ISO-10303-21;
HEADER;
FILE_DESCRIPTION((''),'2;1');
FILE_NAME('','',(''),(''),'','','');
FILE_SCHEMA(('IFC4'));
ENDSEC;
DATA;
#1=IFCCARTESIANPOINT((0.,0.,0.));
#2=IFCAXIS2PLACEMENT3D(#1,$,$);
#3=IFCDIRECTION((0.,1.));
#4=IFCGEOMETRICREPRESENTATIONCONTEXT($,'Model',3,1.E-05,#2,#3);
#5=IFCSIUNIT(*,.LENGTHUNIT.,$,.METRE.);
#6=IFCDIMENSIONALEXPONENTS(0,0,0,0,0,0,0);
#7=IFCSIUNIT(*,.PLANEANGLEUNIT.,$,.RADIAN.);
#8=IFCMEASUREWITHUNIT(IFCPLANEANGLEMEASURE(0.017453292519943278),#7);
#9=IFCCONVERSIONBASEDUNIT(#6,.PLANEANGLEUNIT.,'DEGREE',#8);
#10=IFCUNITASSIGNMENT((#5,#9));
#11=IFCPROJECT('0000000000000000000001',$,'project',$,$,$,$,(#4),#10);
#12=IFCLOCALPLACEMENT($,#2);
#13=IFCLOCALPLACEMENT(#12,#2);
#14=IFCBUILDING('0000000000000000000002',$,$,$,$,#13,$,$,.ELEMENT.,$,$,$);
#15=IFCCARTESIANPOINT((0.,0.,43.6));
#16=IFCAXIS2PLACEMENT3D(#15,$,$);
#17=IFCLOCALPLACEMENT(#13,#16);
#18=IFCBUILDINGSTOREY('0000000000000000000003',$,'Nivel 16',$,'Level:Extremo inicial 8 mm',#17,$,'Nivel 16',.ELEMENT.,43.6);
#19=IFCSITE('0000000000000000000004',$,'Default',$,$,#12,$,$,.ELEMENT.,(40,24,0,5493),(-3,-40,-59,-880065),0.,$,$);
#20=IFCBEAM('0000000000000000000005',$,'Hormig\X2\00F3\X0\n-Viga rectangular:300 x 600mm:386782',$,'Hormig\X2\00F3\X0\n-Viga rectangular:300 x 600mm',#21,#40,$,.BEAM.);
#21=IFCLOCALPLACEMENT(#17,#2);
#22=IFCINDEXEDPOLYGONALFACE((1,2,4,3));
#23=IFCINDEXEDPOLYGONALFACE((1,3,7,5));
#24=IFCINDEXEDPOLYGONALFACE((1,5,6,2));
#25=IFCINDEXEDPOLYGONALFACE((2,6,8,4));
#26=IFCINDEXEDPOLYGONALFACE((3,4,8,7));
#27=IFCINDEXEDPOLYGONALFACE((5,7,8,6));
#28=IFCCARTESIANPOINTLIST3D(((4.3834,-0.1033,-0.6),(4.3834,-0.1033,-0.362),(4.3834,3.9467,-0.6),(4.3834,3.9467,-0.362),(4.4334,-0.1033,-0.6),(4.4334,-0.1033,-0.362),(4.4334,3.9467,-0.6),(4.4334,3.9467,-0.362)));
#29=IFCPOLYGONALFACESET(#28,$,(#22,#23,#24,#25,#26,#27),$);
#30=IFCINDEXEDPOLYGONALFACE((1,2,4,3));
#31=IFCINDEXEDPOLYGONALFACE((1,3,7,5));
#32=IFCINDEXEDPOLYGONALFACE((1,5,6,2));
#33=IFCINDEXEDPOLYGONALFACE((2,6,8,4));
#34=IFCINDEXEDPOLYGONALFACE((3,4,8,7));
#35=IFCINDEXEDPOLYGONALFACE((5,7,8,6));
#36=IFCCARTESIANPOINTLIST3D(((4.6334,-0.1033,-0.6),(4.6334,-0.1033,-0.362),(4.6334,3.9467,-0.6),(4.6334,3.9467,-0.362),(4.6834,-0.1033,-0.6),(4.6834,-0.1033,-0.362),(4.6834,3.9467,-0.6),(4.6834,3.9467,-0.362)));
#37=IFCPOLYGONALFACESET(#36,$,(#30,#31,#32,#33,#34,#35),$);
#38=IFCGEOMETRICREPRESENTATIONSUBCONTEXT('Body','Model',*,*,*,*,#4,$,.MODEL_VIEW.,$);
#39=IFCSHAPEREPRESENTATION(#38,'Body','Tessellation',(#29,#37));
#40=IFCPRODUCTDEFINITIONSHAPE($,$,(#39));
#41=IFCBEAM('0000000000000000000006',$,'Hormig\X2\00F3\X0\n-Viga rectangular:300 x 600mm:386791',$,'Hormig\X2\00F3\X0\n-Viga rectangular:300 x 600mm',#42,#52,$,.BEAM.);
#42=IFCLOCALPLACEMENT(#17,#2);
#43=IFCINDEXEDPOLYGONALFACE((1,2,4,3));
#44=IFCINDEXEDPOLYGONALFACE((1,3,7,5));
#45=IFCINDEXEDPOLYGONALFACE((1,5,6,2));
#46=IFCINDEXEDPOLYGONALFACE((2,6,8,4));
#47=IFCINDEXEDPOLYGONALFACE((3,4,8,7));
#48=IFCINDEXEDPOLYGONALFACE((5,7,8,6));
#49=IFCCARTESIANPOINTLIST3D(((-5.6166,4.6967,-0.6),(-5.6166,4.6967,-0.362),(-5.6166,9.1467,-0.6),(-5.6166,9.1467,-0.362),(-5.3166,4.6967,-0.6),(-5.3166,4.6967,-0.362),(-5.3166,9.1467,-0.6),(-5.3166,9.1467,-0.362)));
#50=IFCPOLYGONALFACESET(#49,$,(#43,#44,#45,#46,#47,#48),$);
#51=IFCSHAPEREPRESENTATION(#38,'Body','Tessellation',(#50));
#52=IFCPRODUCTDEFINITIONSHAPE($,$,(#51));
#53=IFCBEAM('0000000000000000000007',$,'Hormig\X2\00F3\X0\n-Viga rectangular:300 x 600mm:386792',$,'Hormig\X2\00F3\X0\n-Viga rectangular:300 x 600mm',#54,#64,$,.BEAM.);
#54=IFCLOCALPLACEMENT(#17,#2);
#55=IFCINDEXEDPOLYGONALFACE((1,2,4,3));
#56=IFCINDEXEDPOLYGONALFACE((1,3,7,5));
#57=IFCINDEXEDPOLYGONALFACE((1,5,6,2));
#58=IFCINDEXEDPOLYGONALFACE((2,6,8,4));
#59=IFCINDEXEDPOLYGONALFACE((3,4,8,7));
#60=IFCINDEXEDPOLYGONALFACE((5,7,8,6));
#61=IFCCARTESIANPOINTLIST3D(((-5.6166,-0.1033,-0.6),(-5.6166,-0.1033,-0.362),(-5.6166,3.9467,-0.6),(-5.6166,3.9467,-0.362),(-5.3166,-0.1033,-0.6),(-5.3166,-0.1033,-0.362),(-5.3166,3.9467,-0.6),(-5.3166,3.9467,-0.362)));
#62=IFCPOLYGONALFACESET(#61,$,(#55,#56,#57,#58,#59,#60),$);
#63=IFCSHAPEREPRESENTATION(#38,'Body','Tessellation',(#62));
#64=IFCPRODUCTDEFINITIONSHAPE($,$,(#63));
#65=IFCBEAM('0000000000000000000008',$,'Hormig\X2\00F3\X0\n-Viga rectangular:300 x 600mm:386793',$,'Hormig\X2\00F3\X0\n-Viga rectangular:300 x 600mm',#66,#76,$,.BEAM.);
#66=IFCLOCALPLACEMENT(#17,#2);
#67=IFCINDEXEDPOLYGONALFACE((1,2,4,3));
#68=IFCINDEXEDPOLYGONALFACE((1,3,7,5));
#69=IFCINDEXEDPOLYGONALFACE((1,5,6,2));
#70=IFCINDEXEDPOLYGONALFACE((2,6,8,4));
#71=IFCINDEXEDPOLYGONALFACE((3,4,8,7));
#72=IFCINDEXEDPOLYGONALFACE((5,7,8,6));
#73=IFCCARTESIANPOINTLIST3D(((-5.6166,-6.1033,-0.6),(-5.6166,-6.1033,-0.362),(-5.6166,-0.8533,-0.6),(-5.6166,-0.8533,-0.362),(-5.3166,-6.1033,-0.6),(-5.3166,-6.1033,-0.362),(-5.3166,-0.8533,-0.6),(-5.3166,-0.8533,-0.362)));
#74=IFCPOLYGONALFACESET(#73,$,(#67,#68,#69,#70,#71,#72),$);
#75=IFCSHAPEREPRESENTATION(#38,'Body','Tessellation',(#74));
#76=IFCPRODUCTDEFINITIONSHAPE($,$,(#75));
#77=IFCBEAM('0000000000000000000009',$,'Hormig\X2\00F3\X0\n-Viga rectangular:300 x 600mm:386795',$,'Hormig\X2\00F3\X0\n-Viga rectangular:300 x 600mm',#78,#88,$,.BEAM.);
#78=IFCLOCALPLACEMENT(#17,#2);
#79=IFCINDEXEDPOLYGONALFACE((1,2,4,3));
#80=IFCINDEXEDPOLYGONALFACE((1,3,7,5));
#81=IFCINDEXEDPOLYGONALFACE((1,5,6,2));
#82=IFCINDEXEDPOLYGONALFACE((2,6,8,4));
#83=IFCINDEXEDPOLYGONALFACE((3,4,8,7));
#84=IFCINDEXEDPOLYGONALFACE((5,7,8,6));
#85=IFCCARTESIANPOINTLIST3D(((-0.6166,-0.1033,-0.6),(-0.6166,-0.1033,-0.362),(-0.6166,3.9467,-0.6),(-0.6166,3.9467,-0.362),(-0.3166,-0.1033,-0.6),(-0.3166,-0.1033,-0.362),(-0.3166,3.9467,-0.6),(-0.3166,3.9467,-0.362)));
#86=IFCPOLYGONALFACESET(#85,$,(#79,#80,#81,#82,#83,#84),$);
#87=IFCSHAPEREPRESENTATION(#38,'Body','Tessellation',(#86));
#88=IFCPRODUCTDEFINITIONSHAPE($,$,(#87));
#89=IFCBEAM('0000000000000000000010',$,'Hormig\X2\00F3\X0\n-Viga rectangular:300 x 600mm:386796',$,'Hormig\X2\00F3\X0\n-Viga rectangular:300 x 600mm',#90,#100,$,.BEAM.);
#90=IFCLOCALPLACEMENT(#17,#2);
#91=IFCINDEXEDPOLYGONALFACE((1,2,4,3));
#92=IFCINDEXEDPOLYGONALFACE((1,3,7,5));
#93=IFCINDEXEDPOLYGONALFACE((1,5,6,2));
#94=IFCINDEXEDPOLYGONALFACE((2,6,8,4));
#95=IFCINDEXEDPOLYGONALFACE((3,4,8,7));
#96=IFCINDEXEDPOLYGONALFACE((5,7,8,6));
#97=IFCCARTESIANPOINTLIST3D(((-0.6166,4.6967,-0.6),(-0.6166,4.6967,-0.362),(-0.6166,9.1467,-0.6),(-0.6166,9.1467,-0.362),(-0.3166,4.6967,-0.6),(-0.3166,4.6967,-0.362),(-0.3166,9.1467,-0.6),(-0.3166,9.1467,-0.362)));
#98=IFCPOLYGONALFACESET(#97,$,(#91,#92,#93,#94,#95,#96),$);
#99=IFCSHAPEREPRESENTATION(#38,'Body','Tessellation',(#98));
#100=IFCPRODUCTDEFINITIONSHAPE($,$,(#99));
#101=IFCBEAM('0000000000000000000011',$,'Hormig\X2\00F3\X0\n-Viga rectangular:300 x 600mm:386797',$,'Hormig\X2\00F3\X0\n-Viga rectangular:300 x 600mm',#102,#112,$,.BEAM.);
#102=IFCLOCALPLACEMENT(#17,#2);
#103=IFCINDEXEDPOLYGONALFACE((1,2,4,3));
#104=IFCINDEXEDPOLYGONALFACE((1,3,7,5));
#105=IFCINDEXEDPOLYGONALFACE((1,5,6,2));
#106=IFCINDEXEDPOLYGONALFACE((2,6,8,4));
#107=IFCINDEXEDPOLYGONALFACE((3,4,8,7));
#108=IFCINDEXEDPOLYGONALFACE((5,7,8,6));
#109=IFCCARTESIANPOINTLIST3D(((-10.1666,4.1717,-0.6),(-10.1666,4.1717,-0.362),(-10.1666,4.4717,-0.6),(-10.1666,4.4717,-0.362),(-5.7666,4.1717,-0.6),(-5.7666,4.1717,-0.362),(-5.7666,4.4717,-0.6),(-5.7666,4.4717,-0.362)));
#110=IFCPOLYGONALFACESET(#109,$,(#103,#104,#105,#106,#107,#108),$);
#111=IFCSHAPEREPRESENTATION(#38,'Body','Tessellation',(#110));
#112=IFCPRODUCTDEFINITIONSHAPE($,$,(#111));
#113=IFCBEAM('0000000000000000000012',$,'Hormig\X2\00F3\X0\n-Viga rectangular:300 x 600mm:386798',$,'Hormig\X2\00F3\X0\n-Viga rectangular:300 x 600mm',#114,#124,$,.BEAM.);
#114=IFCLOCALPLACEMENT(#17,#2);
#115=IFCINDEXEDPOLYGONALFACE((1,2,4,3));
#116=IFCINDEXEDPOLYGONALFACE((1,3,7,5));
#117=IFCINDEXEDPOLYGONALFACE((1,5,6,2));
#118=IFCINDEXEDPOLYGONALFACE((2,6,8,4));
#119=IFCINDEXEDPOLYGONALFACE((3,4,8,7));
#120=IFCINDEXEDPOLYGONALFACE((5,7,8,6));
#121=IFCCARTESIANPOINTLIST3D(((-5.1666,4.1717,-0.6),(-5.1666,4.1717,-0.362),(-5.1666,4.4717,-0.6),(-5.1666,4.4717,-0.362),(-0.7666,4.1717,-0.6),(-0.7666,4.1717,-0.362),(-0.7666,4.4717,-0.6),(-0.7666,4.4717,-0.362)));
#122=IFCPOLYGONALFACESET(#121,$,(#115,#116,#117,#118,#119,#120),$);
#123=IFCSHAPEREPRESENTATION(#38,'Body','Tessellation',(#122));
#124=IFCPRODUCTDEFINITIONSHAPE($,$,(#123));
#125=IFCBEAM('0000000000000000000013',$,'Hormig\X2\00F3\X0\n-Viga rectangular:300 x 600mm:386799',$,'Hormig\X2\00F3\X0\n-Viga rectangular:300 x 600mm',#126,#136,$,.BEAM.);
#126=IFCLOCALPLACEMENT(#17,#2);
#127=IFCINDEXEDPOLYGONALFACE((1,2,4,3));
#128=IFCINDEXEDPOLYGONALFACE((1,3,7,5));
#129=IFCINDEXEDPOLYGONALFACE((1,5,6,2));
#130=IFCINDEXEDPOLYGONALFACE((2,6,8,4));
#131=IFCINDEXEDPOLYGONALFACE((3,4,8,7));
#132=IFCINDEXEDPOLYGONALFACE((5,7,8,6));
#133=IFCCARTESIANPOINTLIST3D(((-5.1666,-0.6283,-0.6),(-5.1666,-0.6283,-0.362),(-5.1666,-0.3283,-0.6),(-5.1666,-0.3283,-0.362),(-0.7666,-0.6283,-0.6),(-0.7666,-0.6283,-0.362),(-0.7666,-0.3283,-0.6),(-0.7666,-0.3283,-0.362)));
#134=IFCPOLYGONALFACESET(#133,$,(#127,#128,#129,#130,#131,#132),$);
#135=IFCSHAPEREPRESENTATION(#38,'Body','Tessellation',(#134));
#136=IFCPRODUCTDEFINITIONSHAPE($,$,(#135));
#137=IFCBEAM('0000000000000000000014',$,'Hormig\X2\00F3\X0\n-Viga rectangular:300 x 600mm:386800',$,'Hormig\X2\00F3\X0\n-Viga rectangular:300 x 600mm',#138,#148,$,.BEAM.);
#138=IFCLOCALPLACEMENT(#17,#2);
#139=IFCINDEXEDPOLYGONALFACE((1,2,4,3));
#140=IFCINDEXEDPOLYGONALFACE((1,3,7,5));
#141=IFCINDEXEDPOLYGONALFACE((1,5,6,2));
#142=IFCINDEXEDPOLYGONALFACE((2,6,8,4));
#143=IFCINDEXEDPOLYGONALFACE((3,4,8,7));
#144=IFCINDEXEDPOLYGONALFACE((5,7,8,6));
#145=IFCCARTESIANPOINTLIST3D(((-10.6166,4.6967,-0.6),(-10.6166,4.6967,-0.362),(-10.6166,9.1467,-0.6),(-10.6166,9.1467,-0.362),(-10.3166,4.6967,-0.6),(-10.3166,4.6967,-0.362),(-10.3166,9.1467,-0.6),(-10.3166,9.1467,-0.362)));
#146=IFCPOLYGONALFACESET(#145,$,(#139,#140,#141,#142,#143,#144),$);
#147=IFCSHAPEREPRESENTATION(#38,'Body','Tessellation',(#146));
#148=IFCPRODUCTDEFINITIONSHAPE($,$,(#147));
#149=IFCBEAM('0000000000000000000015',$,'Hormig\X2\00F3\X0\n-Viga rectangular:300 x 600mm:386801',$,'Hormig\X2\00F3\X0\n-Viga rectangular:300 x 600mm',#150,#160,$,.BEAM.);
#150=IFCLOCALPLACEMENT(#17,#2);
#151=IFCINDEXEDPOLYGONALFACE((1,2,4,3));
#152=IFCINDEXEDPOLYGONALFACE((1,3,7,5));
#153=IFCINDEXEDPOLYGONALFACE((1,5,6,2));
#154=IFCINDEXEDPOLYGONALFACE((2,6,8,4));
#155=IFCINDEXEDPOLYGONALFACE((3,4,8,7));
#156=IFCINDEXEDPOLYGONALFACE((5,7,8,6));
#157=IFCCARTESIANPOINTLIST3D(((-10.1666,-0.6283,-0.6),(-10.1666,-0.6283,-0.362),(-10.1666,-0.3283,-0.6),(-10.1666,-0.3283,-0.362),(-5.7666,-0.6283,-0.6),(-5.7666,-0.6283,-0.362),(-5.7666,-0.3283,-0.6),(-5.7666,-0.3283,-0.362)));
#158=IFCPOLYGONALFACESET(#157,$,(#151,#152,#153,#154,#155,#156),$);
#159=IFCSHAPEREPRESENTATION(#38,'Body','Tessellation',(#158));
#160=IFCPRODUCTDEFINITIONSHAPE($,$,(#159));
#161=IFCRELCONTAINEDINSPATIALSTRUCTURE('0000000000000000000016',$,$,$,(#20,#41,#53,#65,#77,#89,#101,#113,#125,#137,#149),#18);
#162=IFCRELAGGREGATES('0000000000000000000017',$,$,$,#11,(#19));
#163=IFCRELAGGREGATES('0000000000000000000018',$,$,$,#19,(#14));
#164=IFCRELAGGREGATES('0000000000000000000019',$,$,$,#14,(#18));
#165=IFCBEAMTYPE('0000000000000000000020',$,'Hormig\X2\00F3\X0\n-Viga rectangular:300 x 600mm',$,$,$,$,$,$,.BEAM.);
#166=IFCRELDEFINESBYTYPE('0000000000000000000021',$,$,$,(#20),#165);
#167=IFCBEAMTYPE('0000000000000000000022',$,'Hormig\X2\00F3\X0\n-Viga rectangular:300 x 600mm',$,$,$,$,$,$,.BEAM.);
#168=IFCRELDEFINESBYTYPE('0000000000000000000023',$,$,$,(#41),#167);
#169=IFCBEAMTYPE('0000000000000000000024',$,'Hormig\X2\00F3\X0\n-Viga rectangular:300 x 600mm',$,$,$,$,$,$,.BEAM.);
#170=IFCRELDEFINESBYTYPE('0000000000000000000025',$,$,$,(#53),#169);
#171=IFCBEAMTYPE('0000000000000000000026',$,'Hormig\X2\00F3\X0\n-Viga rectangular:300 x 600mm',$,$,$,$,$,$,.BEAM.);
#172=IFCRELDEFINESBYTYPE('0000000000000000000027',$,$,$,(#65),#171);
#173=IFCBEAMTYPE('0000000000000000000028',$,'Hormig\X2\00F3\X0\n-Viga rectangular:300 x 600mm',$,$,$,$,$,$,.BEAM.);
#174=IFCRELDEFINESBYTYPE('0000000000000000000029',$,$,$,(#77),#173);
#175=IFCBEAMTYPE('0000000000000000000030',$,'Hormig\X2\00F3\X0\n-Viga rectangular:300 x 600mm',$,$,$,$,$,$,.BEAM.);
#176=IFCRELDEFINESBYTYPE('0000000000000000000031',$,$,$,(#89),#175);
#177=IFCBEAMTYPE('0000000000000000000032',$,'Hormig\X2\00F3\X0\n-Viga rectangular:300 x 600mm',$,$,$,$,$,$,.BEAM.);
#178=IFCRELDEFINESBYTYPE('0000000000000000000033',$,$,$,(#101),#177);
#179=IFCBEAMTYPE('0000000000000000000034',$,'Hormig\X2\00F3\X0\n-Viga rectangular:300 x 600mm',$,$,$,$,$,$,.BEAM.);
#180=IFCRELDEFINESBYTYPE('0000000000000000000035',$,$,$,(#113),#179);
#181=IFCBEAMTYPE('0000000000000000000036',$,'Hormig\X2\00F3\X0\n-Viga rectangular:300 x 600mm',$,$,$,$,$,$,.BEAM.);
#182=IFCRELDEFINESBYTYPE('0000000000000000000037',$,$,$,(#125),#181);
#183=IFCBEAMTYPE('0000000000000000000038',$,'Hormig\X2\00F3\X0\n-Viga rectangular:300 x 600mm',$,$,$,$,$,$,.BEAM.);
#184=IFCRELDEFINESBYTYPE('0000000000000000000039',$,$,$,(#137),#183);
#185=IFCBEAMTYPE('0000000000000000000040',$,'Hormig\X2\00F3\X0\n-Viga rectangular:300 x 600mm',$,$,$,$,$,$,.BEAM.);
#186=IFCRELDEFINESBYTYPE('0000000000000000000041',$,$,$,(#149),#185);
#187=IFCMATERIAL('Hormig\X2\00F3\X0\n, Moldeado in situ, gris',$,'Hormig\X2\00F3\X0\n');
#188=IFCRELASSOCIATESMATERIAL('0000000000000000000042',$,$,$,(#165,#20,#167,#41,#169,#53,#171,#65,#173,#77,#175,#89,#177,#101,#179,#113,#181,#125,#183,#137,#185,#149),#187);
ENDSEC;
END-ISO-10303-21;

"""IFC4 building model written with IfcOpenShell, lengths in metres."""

from ifc_helpers import new_model, entity, si_unit, converted_unit, direction, frame, origin, place, context, subcontext, project, spatial, indexed_curve, outline, extrude, source, transform, mapped, material, type_object, type_shapes, element, save


model = new_model("IFC4")

# Units and contexts
model_context = context("Model", 3, precision=1e-05, world=origin(), true_north=direction((0.0, 1.0)))
body_context = subcontext(model_context, "Body", "Model", "MODEL_VIEW")
ifc_project = project(units=[si_unit("LENGTHUNIT", "METRE"), converted_unit("PLANEANGLEUNIT", "DEGREE", entity("IfcPlaneAngleMeasure", 0.017453292519943278), si_unit("PLANEANGLEUNIT", "RADIAN"), dimensions=[0, 0, 0, 0, 0, 0, 0])], contexts=[model_context])

# Site, building, storey
site_placement = place(None, origin())
site = spatial("IfcSite", under=ifc_project, at=site_placement, Name="Default", CompositionType="ELEMENT", RefLatitude=(40, 24, 0, 5493), RefLongitude=(-3, -40, -59, -880065), RefElevation=0.0)
building_placement = place(site_placement, origin())
building = spatial("IfcBuilding", under=site, at=building_placement, CompositionType="ELEMENT")
storey_placement = place(building_placement, frame((0.0, 0.0, 43.6)))
storey = spatial("IfcBuildingStorey", under=building, at=storey_placement, Name="Nivel 16", ObjectType="Level:Extremo inicial 8 mm", LongName="Nivel 16", CompositionType="ELEMENT", Elevation=43.6)

# Shared definitions
ifc_material_1 = material(Name="Hormigón, Moldeado in situ, gris", Category="Hormigón")

# Beams
beam_type_1 = type_object("IfcBeamType", Name="Hormigón-Viga rectangular:300 x 600mm", PredefinedType="BEAM", material=ifc_material_1)
shared_shape_1 = source(origin(), body_context, "Body", "SweptSolid", [
    extrude(outline(indexed_curve([(-0.025, -0.119), (0.025, -0.119), (0.025, 0.119), (-0.025, 0.119), (-0.025, -0.119)], self_intersect=False)), frame((4.4084, 3.9467, 43.119), z_axis=(0.0, -1.0, 0.0), x_axis=(-1.0, 0.0, 0.0)), (0.0, 0.0, 1.0), 4.05),
    extrude(outline(indexed_curve([(-0.025, -0.119), (0.025, -0.119), (0.025, 0.119), (-0.025, 0.119), (-0.025, -0.119)], self_intersect=False)), frame((4.6584, 3.9467, 43.119), z_axis=(0.0, -1.0, 0.0), x_axis=(-1.0, 0.0, 0.0)), (0.0, 0.0, 1.0), 4.05),
])
type_shapes(beam_type_1, [shared_shape_1])
beam_1_placement = place(storey_placement, frame((0.0, 0.0, -43.6)))
element("IfcBeam", 1, at=beam_1_placement, inside=storey, type_object=beam_type_1, material=ifc_material_1, Name="Hormigón-Viga rectangular:300 x 600mm:386782", ObjectType="Hormigón-Viga rectangular:300 x 600mm", PredefinedType="BEAM", context=body_context, shape_type="MappedRepresentation", body=[
    mapped(shared_shape_1, transform((0.0, 0.0, 0.0), scale=1.0)),
])
beam_type_2 = type_object("IfcBeamType", Name="Hormigón-Viga rectangular:300 x 600mm", PredefinedType="BEAM", material=ifc_material_1)
shared_shape_2 = source(origin(), body_context, "Body", "SweptSolid", [
    extrude(outline(indexed_curve([(-0.15, -0.119), (0.15, -0.119), (0.15, 0.119), (-0.15, 0.119), (-0.15, -0.119)], self_intersect=False)), frame((-5.4666, 9.1467, 43.119), z_axis=(0.0, -1.0, 0.0), x_axis=(-1.0, 0.0, 0.0)), (0.0, 0.0, 1.0), 4.45),
])
type_shapes(beam_type_2, [shared_shape_2])
beam_2_placement = place(storey_placement, frame((0.0, 0.0, -43.6)))
element("IfcBeam", 2, at=beam_2_placement, inside=storey, type_object=beam_type_2, material=ifc_material_1, Name="Hormigón-Viga rectangular:300 x 600mm:386791", ObjectType="Hormigón-Viga rectangular:300 x 600mm", PredefinedType="BEAM", context=body_context, shape_type="MappedRepresentation", body=[
    mapped(shared_shape_2, transform((0.0, 0.0, 0.0), scale=1.0)),
])
beam_type_3 = type_object("IfcBeamType", Name="Hormigón-Viga rectangular:300 x 600mm", PredefinedType="BEAM", material=ifc_material_1)
shared_shape_3 = source(origin(), body_context, "Body", "SweptSolid", [
    extrude(outline(indexed_curve([(-0.15, -0.119), (0.15, -0.119), (0.15, 0.119), (-0.15, 0.119), (-0.15, -0.119)], self_intersect=False)), frame((-5.4666, 3.9467, 43.119), z_axis=(0.0, -1.0, 0.0), x_axis=(-1.0, 0.0, 0.0)), (0.0, 0.0, 1.0), 4.05),
])
type_shapes(beam_type_3, [shared_shape_3])
beam_3_placement = place(storey_placement, frame((0.0, 0.0, -43.6)))
element("IfcBeam", 3, at=beam_3_placement, inside=storey, type_object=beam_type_3, material=ifc_material_1, Name="Hormigón-Viga rectangular:300 x 600mm:386792", ObjectType="Hormigón-Viga rectangular:300 x 600mm", PredefinedType="BEAM", context=body_context, shape_type="MappedRepresentation", body=[
    mapped(shared_shape_3, transform((0.0, 0.0, 0.0), scale=1.0)),
])
beam_type_4 = type_object("IfcBeamType", Name="Hormigón-Viga rectangular:300 x 600mm", PredefinedType="BEAM", material=ifc_material_1)
shared_shape_4 = source(origin(), body_context, "Body", "SweptSolid", [
    extrude(outline(indexed_curve([(-0.15, -0.119), (0.15, -0.119), (0.15, 0.119), (-0.15, 0.119), (-0.15, -0.119)], self_intersect=False)), frame((-5.4666, -6.1033, 43.119), z_axis=(0.0, 1.0, 0.0), x_axis=(-1.0, 0.0, 0.0)), (0.0, 0.0, 1.0), 5.25),
])
type_shapes(beam_type_4, [shared_shape_4])
beam_4_placement = place(storey_placement, frame((0.0, 0.0, -43.6)))
element("IfcBeam", 4, at=beam_4_placement, inside=storey, type_object=beam_type_4, material=ifc_material_1, Name="Hormigón-Viga rectangular:300 x 600mm:386793", ObjectType="Hormigón-Viga rectangular:300 x 600mm", PredefinedType="BEAM", context=body_context, shape_type="MappedRepresentation", body=[
    mapped(shared_shape_4, transform((0.0, 0.0, 0.0), scale=1.0)),
])
beam_type_5 = type_object("IfcBeamType", Name="Hormigón-Viga rectangular:300 x 600mm", PredefinedType="BEAM", material=ifc_material_1)
shared_shape_5 = source(origin(), body_context, "Body", "SweptSolid", [
    extrude(outline(indexed_curve([(-0.15, -0.119), (0.15, -0.119), (0.15, 0.119), (-0.15, 0.119), (-0.15, -0.119)], self_intersect=False)), frame((-0.4666, -0.1033, 43.119), z_axis=(0.0, 1.0, 0.0), x_axis=(-1.0, 0.0, 0.0)), (0.0, 0.0, 1.0), 4.05),
])
type_shapes(beam_type_5, [shared_shape_5])
beam_5_placement = place(storey_placement, frame((0.0, 0.0, -43.6)))
element("IfcBeam", 5, at=beam_5_placement, inside=storey, type_object=beam_type_5, material=ifc_material_1, Name="Hormigón-Viga rectangular:300 x 600mm:386795", ObjectType="Hormigón-Viga rectangular:300 x 600mm", PredefinedType="BEAM", context=body_context, shape_type="MappedRepresentation", body=[
    mapped(shared_shape_5, transform((0.0, 0.0, 0.0), scale=1.0)),
])
beam_type_6 = type_object("IfcBeamType", Name="Hormigón-Viga rectangular:300 x 600mm", PredefinedType="BEAM", material=ifc_material_1)
shared_shape_6 = source(origin(), body_context, "Body", "SweptSolid", [
    extrude(outline(indexed_curve([(-0.15, -0.119), (0.15, -0.119), (0.15, 0.119), (-0.15, 0.119), (-0.15, -0.119)], self_intersect=False)), frame((-0.4666, 9.1467, 43.119), z_axis=(0.0, -1.0, 0.0), x_axis=(-1.0, 0.0, 0.0)), (0.0, 0.0, 1.0), 4.45),
])
type_shapes(beam_type_6, [shared_shape_6])
beam_6_placement = place(storey_placement, frame((0.0, 0.0, -43.6)))
element("IfcBeam", 6, at=beam_6_placement, inside=storey, type_object=beam_type_6, material=ifc_material_1, Name="Hormigón-Viga rectangular:300 x 600mm:386796", ObjectType="Hormigón-Viga rectangular:300 x 600mm", PredefinedType="BEAM", context=body_context, shape_type="MappedRepresentation", body=[
    mapped(shared_shape_6, transform((0.0, 0.0, 0.0), scale=1.0)),
])
beam_type_7 = type_object("IfcBeamType", Name="Hormigón-Viga rectangular:300 x 600mm", PredefinedType="BEAM", material=ifc_material_1)
shared_shape_7 = source(origin(), body_context, "Body", "SweptSolid", [
    extrude(outline(indexed_curve([(-0.119, -0.15), (0.119, -0.15), (0.119, 0.15), (-0.119, 0.15), (-0.119, -0.15)], self_intersect=False)), frame((-10.1666, 4.3217, 43.119), z_axis=(1.0, 0.0, 0.0), x_axis=(0.0, 0.0, -1.0)), (0.0, 0.0, 1.0), 4.4),
])
type_shapes(beam_type_7, [shared_shape_7])
beam_7_placement = place(storey_placement, frame((0.0, 0.0, -43.6)))
element("IfcBeam", 7, at=beam_7_placement, inside=storey, type_object=beam_type_7, material=ifc_material_1, Name="Hormigón-Viga rectangular:300 x 600mm:386797", ObjectType="Hormigón-Viga rectangular:300 x 600mm", PredefinedType="BEAM", context=body_context, shape_type="MappedRepresentation", body=[
    mapped(shared_shape_7, transform((0.0, 0.0, 0.0), scale=1.0)),
])
beam_type_8 = type_object("IfcBeamType", Name="Hormigón-Viga rectangular:300 x 600mm", PredefinedType="BEAM", material=ifc_material_1)
shared_shape_8 = source(origin(), body_context, "Body", "SweptSolid", [
    extrude(outline(indexed_curve([(-0.119, -0.15), (0.119, -0.15), (0.119, 0.15), (-0.119, 0.15), (-0.119, -0.15)], self_intersect=False)), frame((-5.1666, 4.3217, 43.119), z_axis=(1.0, 0.0, 0.0), x_axis=(0.0, 0.0, -1.0)), (0.0, 0.0, 1.0), 4.4),
])
type_shapes(beam_type_8, [shared_shape_8])
beam_8_placement = place(storey_placement, frame((0.0, 0.0, -43.6)))
element("IfcBeam", 8, at=beam_8_placement, inside=storey, type_object=beam_type_8, material=ifc_material_1, Name="Hormigón-Viga rectangular:300 x 600mm:386798", ObjectType="Hormigón-Viga rectangular:300 x 600mm", PredefinedType="BEAM", context=body_context, shape_type="MappedRepresentation", body=[
    mapped(shared_shape_8, transform((0.0, 0.0, 0.0), scale=1.0)),
])
beam_type_9 = type_object("IfcBeamType", Name="Hormigón-Viga rectangular:300 x 600mm", PredefinedType="BEAM", material=ifc_material_1)
shared_shape_9 = source(origin(), body_context, "Body", "SweptSolid", [
    extrude(outline(indexed_curve([(-0.119, -0.15), (0.119, -0.15), (0.119, 0.15), (-0.119, 0.15), (-0.119, -0.15)], self_intersect=False)), frame((-0.7666, -0.4783, 43.119), z_axis=(-1.0, 0.0, 0.0), x_axis=(0.0, 0.0, -1.0)), (0.0, 0.0, 1.0), 4.4),
])
type_shapes(beam_type_9, [shared_shape_9])
beam_9_placement = place(storey_placement, frame((0.0, 0.0, -43.6)))
element("IfcBeam", 9, at=beam_9_placement, inside=storey, type_object=beam_type_9, material=ifc_material_1, Name="Hormigón-Viga rectangular:300 x 600mm:386799", ObjectType="Hormigón-Viga rectangular:300 x 600mm", PredefinedType="BEAM", context=body_context, shape_type="MappedRepresentation", body=[
    mapped(shared_shape_9, transform((0.0, 0.0, 0.0), scale=1.0)),
])
beam_type_10 = type_object("IfcBeamType", Name="Hormigón-Viga rectangular:300 x 600mm", PredefinedType="BEAM", material=ifc_material_1)
shared_shape_10 = source(origin(), body_context, "Body", "SweptSolid", [
    extrude(outline(indexed_curve([(-0.15, -0.119), (0.15, -0.119), (0.15, 0.119), (-0.15, 0.119), (-0.15, -0.119)], self_intersect=False)), frame((-10.4666, 4.6967, 43.119), z_axis=(0.0, 1.0, 0.0), x_axis=(-1.0, 0.0, 0.0)), (0.0, 0.0, 1.0), 4.45),
])
type_shapes(beam_type_10, [shared_shape_10])
beam_10_placement = place(storey_placement, frame((0.0, 0.0, -43.6)))
element("IfcBeam", 10, at=beam_10_placement, inside=storey, type_object=beam_type_10, material=ifc_material_1, Name="Hormigón-Viga rectangular:300 x 600mm:386800", ObjectType="Hormigón-Viga rectangular:300 x 600mm", PredefinedType="BEAM", context=body_context, shape_type="MappedRepresentation", body=[
    mapped(shared_shape_10, transform((0.0, 0.0, 0.0), scale=1.0)),
])
beam_type_11 = type_object("IfcBeamType", Name="Hormigón-Viga rectangular:300 x 600mm", PredefinedType="BEAM", material=ifc_material_1)
shared_shape_11 = source(origin(), body_context, "Body", "SweptSolid", [
    extrude(outline(indexed_curve([(-0.119, -0.15), (0.119, -0.15), (0.119, 0.15), (-0.119, 0.15), (-0.119, -0.15)], self_intersect=False)), frame((-10.1666, -0.4783, 43.119), z_axis=(1.0, 0.0, 0.0), x_axis=(0.0, 0.0, -1.0)), (0.0, 0.0, 1.0), 4.4),
])
type_shapes(beam_type_11, [shared_shape_11])
beam_11_placement = place(storey_placement, frame((0.0, 0.0, -43.6)))
element("IfcBeam", 11, at=beam_11_placement, inside=storey, type_object=beam_type_11, material=ifc_material_1, Name="Hormigón-Viga rectangular:300 x 600mm:386801", ObjectType="Hormigón-Viga rectangular:300 x 600mm", PredefinedType="BEAM", context=body_context, shape_type="MappedRepresentation", body=[
    mapped(shared_shape_11, transform((0.0, 0.0, 0.0), scale=1.0)),
])

save(model, "model.ifc")
